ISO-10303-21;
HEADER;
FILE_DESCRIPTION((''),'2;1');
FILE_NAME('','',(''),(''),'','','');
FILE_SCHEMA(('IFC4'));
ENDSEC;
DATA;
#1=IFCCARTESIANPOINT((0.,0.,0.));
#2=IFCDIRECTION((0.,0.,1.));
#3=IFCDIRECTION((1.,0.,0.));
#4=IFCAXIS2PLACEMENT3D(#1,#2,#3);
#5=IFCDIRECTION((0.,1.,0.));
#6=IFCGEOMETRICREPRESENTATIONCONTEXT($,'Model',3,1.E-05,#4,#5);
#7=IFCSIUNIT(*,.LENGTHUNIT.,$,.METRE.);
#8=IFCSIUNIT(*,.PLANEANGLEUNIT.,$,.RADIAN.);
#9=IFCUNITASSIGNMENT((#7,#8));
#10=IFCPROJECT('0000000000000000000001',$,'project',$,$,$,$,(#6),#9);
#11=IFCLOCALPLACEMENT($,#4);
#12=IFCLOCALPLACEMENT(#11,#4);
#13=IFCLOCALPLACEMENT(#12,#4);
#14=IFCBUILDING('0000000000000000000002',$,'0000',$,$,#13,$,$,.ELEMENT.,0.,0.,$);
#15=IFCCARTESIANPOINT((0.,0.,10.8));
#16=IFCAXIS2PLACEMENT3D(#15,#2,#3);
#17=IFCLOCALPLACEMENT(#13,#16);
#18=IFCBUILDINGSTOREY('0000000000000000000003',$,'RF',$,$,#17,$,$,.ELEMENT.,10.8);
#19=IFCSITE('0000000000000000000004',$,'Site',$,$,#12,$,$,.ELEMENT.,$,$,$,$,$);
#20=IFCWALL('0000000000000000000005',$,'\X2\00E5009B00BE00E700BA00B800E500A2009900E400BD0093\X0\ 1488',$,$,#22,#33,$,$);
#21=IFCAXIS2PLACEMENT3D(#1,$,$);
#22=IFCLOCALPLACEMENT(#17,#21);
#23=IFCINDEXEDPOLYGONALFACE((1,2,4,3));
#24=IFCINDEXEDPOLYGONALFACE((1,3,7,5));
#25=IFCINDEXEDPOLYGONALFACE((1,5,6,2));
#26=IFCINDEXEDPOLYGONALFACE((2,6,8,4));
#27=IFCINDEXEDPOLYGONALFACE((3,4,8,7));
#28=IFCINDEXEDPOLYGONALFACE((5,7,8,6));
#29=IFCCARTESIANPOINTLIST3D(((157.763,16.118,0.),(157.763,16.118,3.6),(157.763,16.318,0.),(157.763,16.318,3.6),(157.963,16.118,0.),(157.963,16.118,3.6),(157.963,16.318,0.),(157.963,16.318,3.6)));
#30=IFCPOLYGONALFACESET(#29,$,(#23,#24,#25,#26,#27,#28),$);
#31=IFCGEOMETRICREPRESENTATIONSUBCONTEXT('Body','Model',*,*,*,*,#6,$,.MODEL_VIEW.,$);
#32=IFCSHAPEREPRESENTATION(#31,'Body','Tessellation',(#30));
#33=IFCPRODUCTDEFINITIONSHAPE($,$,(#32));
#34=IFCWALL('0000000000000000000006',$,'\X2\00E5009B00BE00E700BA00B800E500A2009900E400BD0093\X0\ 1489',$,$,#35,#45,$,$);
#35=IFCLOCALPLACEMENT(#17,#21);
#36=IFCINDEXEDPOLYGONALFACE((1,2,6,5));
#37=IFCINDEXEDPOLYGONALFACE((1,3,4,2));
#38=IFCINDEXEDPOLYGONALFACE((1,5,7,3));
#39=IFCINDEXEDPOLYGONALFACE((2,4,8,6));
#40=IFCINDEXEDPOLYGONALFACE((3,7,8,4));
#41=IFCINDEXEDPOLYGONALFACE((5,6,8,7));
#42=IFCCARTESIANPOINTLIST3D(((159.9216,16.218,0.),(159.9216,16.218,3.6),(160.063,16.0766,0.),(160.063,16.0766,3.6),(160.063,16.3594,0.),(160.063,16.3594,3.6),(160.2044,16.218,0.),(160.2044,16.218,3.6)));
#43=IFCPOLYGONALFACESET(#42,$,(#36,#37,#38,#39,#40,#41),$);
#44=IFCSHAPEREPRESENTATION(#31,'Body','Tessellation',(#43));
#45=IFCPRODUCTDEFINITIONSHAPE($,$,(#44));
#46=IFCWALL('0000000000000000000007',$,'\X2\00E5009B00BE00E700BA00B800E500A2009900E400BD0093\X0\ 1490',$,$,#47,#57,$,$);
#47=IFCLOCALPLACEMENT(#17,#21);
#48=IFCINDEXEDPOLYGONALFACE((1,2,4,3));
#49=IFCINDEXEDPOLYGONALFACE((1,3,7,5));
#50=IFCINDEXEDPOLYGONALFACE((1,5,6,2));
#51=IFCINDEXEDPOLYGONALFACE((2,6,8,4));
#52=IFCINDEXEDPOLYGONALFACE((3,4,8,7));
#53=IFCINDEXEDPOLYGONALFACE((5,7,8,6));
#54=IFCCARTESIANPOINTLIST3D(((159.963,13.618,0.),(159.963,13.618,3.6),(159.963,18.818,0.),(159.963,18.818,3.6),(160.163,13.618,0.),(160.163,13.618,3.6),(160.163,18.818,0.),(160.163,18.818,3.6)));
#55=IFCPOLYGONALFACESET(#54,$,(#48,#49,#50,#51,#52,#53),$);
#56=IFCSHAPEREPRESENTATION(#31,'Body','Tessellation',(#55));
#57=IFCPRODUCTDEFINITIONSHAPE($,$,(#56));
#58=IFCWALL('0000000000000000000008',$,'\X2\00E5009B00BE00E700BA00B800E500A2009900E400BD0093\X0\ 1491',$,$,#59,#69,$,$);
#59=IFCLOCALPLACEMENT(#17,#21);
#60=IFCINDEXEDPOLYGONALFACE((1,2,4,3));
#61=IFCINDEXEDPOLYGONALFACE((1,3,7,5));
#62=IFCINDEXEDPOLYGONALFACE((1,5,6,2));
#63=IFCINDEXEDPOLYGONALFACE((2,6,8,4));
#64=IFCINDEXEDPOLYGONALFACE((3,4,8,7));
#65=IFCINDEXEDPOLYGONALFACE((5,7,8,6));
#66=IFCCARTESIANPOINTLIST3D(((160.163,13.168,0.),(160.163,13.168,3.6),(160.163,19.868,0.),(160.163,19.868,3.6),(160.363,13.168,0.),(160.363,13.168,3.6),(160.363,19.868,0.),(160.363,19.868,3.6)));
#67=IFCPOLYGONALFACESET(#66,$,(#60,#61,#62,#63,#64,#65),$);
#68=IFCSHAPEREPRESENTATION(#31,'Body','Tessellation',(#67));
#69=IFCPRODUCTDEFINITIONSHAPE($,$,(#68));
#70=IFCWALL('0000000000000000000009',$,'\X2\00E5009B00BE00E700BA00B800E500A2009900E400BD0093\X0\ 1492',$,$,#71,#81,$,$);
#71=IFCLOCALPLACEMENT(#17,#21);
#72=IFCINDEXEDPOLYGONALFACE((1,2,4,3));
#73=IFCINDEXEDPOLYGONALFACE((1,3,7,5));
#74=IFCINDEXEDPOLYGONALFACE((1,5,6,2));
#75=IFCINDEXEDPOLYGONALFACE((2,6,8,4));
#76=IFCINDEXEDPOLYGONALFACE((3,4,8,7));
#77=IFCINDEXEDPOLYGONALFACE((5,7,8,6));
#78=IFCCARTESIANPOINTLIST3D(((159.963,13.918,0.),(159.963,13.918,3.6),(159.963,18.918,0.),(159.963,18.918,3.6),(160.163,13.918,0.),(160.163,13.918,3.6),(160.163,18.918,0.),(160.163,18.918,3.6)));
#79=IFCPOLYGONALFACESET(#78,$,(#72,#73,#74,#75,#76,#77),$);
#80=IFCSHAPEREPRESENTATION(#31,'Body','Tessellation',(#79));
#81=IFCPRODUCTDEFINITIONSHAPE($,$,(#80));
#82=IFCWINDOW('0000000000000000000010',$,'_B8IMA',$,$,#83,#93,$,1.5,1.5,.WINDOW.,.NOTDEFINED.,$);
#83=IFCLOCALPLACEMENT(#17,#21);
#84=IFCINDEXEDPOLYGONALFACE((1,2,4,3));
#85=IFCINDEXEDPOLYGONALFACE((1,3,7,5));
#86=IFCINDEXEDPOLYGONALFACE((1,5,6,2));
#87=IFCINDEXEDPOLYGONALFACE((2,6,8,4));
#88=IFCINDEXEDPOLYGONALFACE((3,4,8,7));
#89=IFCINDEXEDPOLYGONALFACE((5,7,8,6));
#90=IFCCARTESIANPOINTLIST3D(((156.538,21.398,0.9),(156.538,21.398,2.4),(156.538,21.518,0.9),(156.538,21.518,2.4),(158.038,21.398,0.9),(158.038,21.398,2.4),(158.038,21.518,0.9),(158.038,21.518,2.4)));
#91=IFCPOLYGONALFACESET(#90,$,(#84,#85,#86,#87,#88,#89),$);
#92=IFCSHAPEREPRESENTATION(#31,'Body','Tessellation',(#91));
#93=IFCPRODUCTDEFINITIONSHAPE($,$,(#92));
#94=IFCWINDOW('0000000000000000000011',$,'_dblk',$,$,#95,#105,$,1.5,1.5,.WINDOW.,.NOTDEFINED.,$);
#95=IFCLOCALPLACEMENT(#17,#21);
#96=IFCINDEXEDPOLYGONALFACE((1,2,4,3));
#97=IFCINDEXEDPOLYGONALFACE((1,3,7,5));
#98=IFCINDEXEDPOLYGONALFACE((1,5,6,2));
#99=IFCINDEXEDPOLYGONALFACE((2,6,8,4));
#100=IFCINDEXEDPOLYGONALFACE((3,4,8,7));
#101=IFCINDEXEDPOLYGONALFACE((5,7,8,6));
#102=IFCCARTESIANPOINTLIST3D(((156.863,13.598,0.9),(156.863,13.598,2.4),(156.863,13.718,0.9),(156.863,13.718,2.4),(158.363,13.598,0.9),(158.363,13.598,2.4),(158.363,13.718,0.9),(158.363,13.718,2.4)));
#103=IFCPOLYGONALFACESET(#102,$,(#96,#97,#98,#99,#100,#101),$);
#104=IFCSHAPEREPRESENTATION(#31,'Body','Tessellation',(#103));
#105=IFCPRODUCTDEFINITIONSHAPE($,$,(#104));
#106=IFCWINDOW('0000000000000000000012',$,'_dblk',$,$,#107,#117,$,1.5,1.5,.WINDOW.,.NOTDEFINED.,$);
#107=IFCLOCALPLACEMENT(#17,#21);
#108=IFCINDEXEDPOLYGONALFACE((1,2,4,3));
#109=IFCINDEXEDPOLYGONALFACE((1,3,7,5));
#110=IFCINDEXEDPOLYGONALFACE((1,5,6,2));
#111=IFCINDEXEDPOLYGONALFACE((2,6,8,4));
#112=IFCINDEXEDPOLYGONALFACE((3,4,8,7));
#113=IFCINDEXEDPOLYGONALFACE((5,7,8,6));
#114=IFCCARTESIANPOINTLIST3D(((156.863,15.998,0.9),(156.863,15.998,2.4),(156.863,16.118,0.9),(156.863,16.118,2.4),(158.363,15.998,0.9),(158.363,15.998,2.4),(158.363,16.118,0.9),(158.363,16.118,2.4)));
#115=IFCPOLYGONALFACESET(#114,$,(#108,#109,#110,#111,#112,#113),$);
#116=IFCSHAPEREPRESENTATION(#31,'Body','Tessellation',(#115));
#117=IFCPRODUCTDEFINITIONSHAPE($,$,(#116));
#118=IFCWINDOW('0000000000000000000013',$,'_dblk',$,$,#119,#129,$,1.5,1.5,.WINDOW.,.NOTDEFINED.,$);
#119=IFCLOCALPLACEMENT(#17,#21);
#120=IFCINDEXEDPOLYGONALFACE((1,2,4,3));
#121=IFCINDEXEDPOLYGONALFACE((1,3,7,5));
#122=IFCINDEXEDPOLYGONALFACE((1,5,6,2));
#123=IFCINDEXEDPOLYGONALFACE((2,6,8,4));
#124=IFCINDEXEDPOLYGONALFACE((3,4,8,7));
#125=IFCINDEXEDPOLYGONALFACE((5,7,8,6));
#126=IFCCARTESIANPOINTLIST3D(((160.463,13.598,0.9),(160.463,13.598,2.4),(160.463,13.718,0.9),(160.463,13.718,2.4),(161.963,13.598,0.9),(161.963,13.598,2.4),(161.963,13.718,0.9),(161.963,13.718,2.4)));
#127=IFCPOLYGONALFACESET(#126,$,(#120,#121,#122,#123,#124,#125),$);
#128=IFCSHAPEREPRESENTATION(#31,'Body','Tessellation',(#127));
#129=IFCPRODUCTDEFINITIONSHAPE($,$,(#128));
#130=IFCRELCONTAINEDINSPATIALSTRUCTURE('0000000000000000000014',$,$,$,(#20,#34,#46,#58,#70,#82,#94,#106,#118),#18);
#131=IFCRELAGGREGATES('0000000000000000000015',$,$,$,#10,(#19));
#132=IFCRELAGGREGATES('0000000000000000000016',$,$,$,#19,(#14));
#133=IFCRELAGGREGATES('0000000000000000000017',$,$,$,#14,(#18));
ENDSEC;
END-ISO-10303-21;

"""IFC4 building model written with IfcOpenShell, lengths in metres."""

from ifc_helpers import new_model, si_unit, direction, frame, frame_2d, origin_with_axes, place, context, subcontext, project, spatial, rectangle, extrude, element, save


model = new_model("IFC4")

# Units and contexts
model_context = context("Model", 3, precision=1e-05, world=origin_with_axes(), true_north=direction((0.0, 1.0, 0.0)))
body_context = subcontext(model_context, "Body", "Model", "MODEL_VIEW")
ifc_project = project(units=[si_unit("LENGTHUNIT", "METRE"), si_unit("PLANEANGLEUNIT", "RADIAN")], contexts=[model_context])

# Site, building, storey
placement = place(None, origin_with_axes())
site_placement = place(placement, origin_with_axes())
site = spatial("IfcSite", under=ifc_project, at=site_placement, Name="Site", CompositionType="ELEMENT")
building_placement = place(site_placement, origin_with_axes())
building = spatial("IfcBuilding", under=site, at=building_placement, Name="0000", CompositionType="ELEMENT", ElevationOfRefHeight=0.0, ElevationOfTerrain=0.0)
storey_placement = place(building_placement, frame((0.0, 0.0, 10.8), z_axis=(0.0, 0.0, 1.0), x_axis=(1.0, 0.0, 0.0)))
storey = spatial("IfcBuildingStorey", under=building, at=storey_placement, Name="RF", CompositionType="ELEMENT", Elevation=10.8)

# Walls
for number, where, z_axis, x_axis, name in (
    (1, (157.863, 16.218, 0.0), (0.0, 0.0, 1.0), (0.0, -1.0, 0.0), "å\u009b¾çº¸å¢\u0099ä½\u0093 1488"),
    (2, (160.063, 16.218, 0.0), (0.0, 0.0, 1.0), (-0.707107, -0.707107, 0.0), "å\u009b¾çº¸å¢\u0099ä½\u0093 1489"),
):
    element("IfcWall", number, at=place(storey_placement, frame(where, z_axis=z_axis, x_axis=x_axis)), inside=storey, Name=name, context=body_context, shape_type="SweptSolid", body=[
        extrude(rectangle(XDim=0.2, YDim=0.2, at=frame_2d((0.0, 0.0), x_axis=(1.0, 0.0, 0.0))), frame((0.0, 0.0, 0.0), z_axis=(0.0, 0.0, 1.0)), (0.0, 0.0, 1.0), 3.6),
    ])
wall_1_placement = place(storey_placement, frame((160.063, 16.218, 0.0), z_axis=(0.0, 0.0, 1.0), x_axis=(0.0, 1.0, 0.0)))
element("IfcWall", 3, at=wall_1_placement, inside=storey, Name="å\u009b¾çº¸å¢\u0099ä½\u0093 1490", context=body_context, shape_type="SweptSolid", body=[
    extrude(rectangle(XDim=5.2, YDim=0.2, at=frame_2d((0.0, 0.0), x_axis=(1.0, 0.0, 0.0))), frame((0.0, 0.0, 0.0), z_axis=(0.0, 0.0, 1.0)), (0.0, 0.0, 1.0), 3.6),
])
wall_2_placement = place(storey_placement, frame((160.263, 16.518, 0.0), z_axis=(0.0, 0.0, 1.0), x_axis=(0.0, 1.0, 0.0)))
element("IfcWall", 4, at=wall_2_placement, inside=storey, Name="å\u009b¾çº¸å¢\u0099ä½\u0093 1491", context=body_context, shape_type="SweptSolid", body=[
    extrude(rectangle(XDim=6.7, YDim=0.2, at=frame_2d((0.0, 0.0), x_axis=(1.0, 0.0, 0.0))), frame((0.0, 0.0, 0.0), z_axis=(0.0, 0.0, 1.0)), (0.0, 0.0, 1.0), 3.6),
])
wall_3_placement = place(storey_placement, frame((160.063, 16.418, 0.0), z_axis=(0.0, 0.0, 1.0), x_axis=(0.0, 1.0, 0.0)))
element("IfcWall", 5, at=wall_3_placement, inside=storey, Name="å\u009b¾çº¸å¢\u0099ä½\u0093 1492", context=body_context, shape_type="SweptSolid", body=[
    extrude(rectangle(XDim=5.0, YDim=0.2, at=frame_2d((0.0, 0.0), x_axis=(1.0, 0.0, 0.0))), frame((0.0, 0.0, 0.0), z_axis=(0.0, 0.0, 1.0)), (0.0, 0.0, 1.0), 3.6),
])

# Windows
for number, where, z_axis, x_axis, name in (
    (6, (157.288, 21.458, 0.9), (0.0, 0.0, 1.0), (1.0, 0.0, 0.0), "_B8IMA"),
    (7, (157.613, 13.658, 0.9), (0.0, 0.0, 1.0), (1.0, 0.0, 0.0), "_dblk"),
    (8, (157.613, 16.058, 0.9), (0.0, 0.0, 1.0), (1.0, 0.0, 0.0), "_dblk"),
    (9, (161.213, 13.658, 0.9), (0.0, 0.0, 1.0), (1.0, 0.0, 0.0), "_dblk"),
):
    element("IfcWindow", number, at=place(storey_placement, frame(where, z_axis=z_axis, x_axis=x_axis)), inside=storey, Name=name, OverallHeight=1.5, OverallWidth=1.5, PartitioningType="NOTDEFINED", PredefinedType="WINDOW", context=body_context, shape_type="SweptSolid", body=[
        extrude(rectangle(XDim=1.5, YDim=0.12, at=frame_2d((0.0, 0.0), x_axis=(1.0, 0.0, 0.0))), frame((0.0, 0.0, 0.0), z_axis=(0.0, 0.0, 1.0)), (0.0, 0.0, 1.0), 1.5),
    ])

save(model, "model.ifc")
